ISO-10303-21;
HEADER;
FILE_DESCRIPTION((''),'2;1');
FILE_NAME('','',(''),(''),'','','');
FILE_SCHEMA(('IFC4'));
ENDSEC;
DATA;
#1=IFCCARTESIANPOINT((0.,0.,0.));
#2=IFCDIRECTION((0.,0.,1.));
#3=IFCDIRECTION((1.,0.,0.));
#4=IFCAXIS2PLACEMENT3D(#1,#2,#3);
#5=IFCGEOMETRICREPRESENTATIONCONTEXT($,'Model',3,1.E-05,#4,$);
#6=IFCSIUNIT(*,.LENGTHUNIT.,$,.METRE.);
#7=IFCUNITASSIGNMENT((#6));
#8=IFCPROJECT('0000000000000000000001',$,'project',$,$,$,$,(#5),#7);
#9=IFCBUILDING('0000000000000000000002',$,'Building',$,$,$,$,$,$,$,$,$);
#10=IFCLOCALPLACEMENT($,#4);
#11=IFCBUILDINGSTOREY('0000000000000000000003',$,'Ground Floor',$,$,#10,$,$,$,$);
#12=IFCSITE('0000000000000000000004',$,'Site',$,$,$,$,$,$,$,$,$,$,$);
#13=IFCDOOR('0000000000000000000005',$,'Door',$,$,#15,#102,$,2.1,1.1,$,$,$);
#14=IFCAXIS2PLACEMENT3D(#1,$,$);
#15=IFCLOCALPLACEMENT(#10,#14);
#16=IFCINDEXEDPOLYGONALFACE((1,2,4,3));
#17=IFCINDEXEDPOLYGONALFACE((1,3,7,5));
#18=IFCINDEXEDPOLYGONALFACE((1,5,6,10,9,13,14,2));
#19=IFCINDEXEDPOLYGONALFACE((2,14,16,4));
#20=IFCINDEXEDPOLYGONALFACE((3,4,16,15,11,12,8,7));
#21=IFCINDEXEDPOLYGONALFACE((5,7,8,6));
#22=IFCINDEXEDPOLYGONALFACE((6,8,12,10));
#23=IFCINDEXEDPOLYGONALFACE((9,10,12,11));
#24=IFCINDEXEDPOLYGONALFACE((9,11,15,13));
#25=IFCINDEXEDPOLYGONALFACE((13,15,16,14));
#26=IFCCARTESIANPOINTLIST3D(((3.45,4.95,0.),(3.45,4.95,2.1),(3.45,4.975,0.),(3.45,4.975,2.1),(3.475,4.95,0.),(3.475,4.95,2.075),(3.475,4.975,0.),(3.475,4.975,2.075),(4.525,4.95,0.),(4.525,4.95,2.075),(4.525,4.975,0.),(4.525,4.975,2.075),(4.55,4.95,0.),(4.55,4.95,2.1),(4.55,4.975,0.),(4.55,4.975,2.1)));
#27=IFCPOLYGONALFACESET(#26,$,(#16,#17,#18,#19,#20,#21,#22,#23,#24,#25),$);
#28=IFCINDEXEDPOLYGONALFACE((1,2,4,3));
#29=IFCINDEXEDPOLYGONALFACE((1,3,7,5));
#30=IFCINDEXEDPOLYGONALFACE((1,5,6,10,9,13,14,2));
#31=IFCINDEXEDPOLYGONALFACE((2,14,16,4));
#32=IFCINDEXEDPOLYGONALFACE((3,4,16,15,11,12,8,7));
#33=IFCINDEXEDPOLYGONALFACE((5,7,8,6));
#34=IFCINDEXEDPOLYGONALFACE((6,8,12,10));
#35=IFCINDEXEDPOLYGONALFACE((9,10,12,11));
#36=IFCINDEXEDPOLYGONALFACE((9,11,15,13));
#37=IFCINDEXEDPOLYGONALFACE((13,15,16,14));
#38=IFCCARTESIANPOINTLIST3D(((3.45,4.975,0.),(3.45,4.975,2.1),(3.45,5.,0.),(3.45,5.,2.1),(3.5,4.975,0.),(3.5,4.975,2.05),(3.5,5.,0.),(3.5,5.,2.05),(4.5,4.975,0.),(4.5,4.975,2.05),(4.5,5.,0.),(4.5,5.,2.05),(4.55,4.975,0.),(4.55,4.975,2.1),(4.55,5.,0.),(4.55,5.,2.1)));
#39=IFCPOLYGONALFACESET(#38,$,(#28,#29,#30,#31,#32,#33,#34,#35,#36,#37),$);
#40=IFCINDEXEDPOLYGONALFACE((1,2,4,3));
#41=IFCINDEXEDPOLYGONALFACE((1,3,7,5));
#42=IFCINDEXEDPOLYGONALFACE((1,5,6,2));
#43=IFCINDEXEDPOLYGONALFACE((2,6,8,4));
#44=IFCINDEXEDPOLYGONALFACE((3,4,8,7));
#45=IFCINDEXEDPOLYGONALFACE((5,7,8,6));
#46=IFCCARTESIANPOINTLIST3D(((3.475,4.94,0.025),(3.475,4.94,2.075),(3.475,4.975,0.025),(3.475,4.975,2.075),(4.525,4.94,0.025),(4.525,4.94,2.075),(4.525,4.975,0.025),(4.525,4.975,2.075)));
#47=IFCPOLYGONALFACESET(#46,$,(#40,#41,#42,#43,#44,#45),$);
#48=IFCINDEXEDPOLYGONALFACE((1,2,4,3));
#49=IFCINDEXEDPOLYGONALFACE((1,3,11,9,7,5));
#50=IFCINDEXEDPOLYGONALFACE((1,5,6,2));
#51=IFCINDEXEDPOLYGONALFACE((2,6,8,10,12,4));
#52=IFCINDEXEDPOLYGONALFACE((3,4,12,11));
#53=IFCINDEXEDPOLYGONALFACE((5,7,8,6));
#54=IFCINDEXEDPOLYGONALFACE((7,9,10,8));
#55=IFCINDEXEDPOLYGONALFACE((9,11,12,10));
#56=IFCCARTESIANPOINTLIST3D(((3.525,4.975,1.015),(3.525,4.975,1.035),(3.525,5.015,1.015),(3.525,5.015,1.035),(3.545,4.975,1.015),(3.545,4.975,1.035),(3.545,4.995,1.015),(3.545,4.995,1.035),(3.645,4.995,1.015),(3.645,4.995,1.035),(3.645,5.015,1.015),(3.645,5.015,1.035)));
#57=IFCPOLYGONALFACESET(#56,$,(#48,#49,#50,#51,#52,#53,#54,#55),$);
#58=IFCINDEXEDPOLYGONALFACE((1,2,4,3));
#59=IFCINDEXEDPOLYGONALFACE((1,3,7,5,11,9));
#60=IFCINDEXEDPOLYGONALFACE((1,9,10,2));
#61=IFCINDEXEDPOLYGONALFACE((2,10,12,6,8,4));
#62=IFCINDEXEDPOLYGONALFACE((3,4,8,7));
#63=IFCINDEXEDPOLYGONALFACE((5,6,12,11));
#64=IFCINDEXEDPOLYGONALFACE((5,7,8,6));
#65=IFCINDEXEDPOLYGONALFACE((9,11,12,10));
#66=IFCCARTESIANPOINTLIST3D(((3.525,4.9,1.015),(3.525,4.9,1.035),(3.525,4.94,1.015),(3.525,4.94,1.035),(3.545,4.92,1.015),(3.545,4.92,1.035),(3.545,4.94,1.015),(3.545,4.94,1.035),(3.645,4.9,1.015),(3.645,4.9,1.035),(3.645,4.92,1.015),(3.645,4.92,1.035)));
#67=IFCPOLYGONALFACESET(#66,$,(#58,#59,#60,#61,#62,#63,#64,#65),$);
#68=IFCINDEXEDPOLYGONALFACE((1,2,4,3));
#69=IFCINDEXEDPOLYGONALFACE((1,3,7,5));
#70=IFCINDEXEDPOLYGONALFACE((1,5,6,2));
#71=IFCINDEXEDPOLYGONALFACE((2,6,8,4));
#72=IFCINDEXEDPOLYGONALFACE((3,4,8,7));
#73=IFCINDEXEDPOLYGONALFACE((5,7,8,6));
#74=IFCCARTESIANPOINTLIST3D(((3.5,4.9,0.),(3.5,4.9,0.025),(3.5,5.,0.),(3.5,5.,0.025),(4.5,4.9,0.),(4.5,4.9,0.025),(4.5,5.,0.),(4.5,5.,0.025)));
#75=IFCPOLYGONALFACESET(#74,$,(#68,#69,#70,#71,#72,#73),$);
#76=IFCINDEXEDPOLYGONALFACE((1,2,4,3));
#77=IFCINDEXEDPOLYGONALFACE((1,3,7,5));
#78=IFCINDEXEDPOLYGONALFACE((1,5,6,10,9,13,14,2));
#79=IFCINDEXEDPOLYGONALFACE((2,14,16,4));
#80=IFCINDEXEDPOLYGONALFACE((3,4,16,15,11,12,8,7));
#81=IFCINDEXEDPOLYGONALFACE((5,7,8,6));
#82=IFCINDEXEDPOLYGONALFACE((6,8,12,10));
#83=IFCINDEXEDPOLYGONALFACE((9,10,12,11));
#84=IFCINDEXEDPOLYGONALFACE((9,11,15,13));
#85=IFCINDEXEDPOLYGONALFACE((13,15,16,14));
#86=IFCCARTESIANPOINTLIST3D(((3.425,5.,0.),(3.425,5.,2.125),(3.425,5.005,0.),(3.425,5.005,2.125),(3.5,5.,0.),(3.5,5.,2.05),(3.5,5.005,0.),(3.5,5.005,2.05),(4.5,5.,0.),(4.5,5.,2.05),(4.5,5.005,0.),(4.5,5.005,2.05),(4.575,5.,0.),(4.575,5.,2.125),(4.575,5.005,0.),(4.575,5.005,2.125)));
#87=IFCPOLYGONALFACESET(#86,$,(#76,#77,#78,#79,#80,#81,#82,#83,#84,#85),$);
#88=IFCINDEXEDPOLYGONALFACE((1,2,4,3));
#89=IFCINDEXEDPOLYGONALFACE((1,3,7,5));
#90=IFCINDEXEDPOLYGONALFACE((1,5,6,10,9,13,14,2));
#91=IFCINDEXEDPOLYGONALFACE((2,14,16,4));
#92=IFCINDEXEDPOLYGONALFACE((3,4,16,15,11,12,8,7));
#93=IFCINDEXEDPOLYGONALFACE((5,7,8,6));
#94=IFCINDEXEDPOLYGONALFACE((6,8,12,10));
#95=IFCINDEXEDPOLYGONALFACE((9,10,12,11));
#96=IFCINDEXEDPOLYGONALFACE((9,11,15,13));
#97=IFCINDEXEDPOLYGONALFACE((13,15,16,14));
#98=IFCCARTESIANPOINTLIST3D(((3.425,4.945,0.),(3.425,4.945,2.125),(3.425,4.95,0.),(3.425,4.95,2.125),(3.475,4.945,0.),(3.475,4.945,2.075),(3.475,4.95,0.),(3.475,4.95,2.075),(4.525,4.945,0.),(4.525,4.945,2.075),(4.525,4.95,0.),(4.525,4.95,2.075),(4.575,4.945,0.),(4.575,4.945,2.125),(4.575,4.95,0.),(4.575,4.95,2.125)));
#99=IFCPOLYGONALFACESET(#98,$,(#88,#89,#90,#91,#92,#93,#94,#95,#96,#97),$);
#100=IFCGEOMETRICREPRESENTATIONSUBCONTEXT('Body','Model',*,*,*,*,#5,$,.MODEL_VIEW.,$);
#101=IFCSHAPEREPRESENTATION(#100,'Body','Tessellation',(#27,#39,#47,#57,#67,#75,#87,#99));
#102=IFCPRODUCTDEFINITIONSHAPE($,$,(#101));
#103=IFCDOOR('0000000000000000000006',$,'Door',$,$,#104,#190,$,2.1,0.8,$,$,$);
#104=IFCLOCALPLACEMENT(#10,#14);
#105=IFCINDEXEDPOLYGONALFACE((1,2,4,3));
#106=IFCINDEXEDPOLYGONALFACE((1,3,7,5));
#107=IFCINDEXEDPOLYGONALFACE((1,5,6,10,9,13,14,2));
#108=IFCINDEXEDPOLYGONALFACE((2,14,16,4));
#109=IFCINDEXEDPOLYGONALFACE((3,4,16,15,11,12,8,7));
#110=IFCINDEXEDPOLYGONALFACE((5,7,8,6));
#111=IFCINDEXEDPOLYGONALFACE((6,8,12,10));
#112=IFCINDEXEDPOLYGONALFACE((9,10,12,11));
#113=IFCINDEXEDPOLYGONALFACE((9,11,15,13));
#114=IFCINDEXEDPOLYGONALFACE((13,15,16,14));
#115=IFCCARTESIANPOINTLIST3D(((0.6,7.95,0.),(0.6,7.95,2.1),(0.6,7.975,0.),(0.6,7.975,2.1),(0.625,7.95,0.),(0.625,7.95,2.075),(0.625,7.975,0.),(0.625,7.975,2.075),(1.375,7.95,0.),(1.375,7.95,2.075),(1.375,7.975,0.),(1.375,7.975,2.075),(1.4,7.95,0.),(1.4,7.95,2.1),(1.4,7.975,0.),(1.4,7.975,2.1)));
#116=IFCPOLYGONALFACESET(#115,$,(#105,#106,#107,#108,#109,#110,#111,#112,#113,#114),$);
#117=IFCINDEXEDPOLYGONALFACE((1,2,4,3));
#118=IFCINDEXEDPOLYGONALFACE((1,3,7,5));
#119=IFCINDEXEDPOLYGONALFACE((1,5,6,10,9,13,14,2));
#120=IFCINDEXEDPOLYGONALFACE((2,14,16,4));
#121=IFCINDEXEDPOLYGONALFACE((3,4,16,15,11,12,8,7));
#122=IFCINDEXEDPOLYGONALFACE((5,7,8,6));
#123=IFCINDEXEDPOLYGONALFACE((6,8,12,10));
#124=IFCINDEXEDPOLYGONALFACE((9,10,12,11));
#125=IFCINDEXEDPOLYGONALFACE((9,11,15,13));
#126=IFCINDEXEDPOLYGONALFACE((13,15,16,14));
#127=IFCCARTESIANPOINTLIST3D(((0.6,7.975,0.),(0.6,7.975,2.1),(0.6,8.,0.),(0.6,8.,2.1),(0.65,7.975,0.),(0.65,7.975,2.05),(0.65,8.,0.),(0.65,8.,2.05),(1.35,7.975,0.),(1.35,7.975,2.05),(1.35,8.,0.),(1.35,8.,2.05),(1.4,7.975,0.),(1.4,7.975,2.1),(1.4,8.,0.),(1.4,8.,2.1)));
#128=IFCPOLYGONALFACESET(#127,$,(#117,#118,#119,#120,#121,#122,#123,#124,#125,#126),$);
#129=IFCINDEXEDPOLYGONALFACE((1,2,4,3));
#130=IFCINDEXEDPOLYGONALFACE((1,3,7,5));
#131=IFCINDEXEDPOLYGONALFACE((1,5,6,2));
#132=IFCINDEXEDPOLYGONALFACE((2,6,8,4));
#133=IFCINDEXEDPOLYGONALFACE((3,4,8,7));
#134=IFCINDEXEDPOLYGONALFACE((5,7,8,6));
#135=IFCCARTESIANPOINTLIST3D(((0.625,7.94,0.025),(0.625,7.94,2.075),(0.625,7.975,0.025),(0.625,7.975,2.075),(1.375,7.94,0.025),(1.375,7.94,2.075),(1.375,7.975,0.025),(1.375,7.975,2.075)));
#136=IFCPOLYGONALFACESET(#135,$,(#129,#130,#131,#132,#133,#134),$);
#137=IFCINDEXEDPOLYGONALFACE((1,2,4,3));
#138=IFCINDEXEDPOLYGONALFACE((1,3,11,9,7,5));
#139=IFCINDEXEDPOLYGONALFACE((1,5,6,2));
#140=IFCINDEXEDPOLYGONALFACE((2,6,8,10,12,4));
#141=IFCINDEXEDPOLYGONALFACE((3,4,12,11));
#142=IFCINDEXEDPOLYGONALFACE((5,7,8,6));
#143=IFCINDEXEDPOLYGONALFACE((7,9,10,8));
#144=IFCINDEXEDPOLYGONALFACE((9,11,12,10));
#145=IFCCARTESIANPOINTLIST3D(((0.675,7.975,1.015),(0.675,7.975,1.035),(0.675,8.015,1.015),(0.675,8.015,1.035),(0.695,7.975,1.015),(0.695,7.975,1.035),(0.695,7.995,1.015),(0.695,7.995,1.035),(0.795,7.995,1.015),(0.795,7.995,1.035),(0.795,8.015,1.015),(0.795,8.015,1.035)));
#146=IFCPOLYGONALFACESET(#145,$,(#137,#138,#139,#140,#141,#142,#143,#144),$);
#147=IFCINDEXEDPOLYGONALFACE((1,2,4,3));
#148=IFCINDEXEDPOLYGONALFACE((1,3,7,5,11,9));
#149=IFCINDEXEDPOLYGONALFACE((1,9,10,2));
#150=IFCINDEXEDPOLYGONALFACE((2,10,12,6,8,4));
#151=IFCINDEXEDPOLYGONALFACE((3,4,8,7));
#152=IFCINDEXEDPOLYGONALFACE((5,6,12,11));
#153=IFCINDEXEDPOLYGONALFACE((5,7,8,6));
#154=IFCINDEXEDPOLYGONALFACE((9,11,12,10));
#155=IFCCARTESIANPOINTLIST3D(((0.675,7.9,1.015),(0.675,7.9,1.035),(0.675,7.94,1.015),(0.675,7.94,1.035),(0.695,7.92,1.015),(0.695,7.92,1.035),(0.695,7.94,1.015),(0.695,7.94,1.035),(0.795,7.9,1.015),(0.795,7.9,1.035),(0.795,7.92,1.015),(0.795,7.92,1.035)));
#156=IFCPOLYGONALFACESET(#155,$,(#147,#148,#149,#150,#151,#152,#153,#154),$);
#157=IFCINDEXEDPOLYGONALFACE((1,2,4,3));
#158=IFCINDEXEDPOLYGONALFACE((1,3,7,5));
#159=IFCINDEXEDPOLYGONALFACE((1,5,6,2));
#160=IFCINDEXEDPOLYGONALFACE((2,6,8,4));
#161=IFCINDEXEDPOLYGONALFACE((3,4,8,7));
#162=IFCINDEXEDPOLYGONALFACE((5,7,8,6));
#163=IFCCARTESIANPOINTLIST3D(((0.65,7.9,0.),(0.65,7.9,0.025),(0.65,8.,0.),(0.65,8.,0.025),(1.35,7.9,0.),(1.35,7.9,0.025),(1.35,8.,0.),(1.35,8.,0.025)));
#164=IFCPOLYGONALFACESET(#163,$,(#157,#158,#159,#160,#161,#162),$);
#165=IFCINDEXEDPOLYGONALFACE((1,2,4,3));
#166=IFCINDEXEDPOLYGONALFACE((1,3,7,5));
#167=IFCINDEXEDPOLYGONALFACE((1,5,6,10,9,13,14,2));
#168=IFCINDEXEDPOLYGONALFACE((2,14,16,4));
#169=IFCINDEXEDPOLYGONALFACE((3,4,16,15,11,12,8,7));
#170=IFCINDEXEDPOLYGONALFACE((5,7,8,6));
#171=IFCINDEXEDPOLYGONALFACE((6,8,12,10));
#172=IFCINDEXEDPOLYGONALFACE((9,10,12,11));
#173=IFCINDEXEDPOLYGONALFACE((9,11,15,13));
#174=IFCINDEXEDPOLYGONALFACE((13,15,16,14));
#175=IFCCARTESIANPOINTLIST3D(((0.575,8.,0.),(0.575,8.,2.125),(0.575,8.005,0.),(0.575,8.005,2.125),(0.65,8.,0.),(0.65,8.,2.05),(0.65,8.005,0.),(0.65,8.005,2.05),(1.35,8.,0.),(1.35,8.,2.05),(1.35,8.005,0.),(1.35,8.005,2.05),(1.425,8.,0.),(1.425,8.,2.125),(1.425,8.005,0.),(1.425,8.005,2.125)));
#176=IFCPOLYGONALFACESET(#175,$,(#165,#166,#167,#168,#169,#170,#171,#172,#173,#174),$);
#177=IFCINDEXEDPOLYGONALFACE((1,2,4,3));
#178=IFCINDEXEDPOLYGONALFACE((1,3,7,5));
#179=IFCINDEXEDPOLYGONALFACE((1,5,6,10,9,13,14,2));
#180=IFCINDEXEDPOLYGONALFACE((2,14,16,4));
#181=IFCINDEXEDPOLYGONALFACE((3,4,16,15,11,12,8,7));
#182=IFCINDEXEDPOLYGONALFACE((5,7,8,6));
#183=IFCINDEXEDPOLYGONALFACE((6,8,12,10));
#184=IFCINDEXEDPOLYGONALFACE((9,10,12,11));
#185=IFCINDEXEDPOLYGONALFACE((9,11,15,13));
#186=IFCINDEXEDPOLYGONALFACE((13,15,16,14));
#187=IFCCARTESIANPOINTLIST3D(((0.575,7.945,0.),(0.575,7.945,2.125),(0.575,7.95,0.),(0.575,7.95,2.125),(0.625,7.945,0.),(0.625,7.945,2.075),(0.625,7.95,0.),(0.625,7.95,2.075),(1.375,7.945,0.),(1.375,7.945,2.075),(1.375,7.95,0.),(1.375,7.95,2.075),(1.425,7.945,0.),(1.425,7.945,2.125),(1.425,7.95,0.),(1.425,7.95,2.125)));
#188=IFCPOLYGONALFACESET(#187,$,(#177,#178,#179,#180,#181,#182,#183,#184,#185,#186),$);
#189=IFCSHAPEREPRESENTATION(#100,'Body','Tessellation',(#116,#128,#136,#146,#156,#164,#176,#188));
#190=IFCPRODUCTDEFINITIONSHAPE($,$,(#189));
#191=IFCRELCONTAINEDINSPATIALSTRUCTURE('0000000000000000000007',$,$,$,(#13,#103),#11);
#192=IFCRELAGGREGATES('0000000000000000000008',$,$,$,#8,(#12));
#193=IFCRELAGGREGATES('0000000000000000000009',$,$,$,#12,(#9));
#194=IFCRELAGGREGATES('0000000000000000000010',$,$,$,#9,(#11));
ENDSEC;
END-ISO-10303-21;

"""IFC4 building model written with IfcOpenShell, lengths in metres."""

from ifc_helpers import new_model, si_unit, frame, origin_with_axes, place, context, subcontext, project, spatial, line, indexed_curve, outline, extrude, element, save


model = new_model("IFC4")

# Units and contexts
model_context = context("Model", 3, precision=1e-05, world=origin_with_axes())
body_context = subcontext(model_context, "Body", "Model", "MODEL_VIEW")
ifc_project = project(units=[si_unit("LENGTHUNIT", "METRE")], contexts=[model_context])

# Site, building, storey
site = spatial("IfcSite", under=ifc_project, Name="Site")
building = spatial("IfcBuilding", under=site, Name="Building")
storey_placement = place(None, origin_with_axes())
storey = spatial("IfcBuildingStorey", under=building, at=storey_placement, Name="Ground Floor")

# Doors
door_1_placement = place(storey_placement, frame((4.55, 5.0, 0.0), z_axis=(0.0, 0.0, 1.0), x_axis=(-1.0, 0.0, 0.0)))
element("IfcDoor", 1, at=door_1_placement, inside=storey, Name="Door", OverallHeight=2.1, OverallWidth=1.1, context=body_context, shape_type="SweptSolid", body=[
    extrude(outline(indexed_curve([(0.0, 0.0), (0.0, 2.1), (1.1, 2.1), (1.1, 0.0), (1.075, 0.0), (1.075, 2.075), (0.025, 2.075), (0.025, 0.0)], segments=[line(1, 2, 3, 4, 5, 6, 7, 8, 1)])), frame((0.0, 0.025, 0.0), z_axis=(0.0, -1.0, 0.0), x_axis=(1.0, 0.0, 0.0)), (0.0, 0.0, -1.0), 0.025),
    extrude(outline(indexed_curve([(0.0, 0.0), (0.0, 2.1), (1.1, 2.1), (1.1, 0.0), (1.05, 0.0), (1.05, 2.05), (0.05, 2.05), (0.05, 0.0)], segments=[line(1, 2, 3, 4, 5, 6, 7, 8, 1)])), frame((0.0, 0.0, 0.0), z_axis=(0.0, -1.0, 0.0), x_axis=(1.0, 0.0, 0.0)), (0.0, 0.0, -1.0), 0.025),
    extrude(outline(indexed_curve([(0.0, 0.0), (1.05, 0.0), (1.05, 0.035), (0.0, 0.035)], segments=[line(1, 2, 3, 4, 1)])), frame((0.025, 0.025, 0.025), z_axis=(0.0, 0.0, 1.0), x_axis=(1.0, 0.0, 0.0)), (0.0, 0.0, 1.0), 2.05),
    extrude(outline(indexed_curve([(0.0, 0.0), (0.0, -0.04), (-0.12, -0.04), (-0.12, -0.02), (-0.02, -0.02), (-0.02, 0.0)], segments=[line(1, 2, 3, 4, 5, 6, 1)])), frame((1.025, 0.025, 1.015), z_axis=(0.0, 0.0, 1.0), x_axis=(1.0, 0.0, 0.0)), (0.0, 0.0, 1.0), 0.02),
    extrude(outline(indexed_curve([(0.0, 0.0), (0.0, 0.04), (-0.12, 0.04), (-0.12, 0.02), (-0.02, 0.02), (-0.02, 0.0)], segments=[line(1, 2, 3, 4, 5, 6, 1)])), frame((1.025, 0.06, 1.015), z_axis=(0.0, 0.0, 1.0), x_axis=(1.0, 0.0, 0.0)), (0.0, 0.0, 1.0), 0.02),
    extrude(outline(indexed_curve([(0.0, 0.0), (1.0, 0.0), (1.0, 0.1), (0.0, 0.1)], segments=[line(1, 2, 3, 4, 1)])), frame((0.05, 0.0, 0.0), z_axis=(0.0, 0.0, 1.0), x_axis=(1.0, 0.0, 0.0)), (0.0, 0.0, 1.0), 0.025),
    extrude(outline(indexed_curve([(0.0, 0.0), (0.0, 2.125), (1.15, 2.125), (1.15, 0.0), (1.075, 0.0), (1.075, 2.05), (0.075, 2.05), (0.075, 0.0)], segments=[line(1, 2, 3, 4, 5, 6, 7, 8, 1)])), frame((-0.025, -0.005, 0.0), z_axis=(0.0, -1.0, 0.0), x_axis=(1.0, 0.0, 0.0)), (0.0, 0.0, -1.0), 0.005),
    extrude(outline(indexed_curve([(0.0, 0.0), (0.0, 2.125), (1.15, 2.125), (1.15, 0.0), (1.1, 0.0), (1.1, 2.075), (0.05, 2.075), (0.05, 0.0)], segments=[line(1, 2, 3, 4, 5, 6, 7, 8, 1)])), frame((-0.025, 0.05, 0.0), z_axis=(0.0, -1.0, 0.0), x_axis=(1.0, 0.0, 0.0)), (0.0, 0.0, -1.0), 0.005),
])
door_2_placement = place(storey_placement, frame((1.4, 8.0, 0.0), z_axis=(0.0, 0.0, 1.0), x_axis=(-1.0, 0.0, 0.0)))
element("IfcDoor", 2, at=door_2_placement, inside=storey, Name="Door", OverallHeight=2.1, OverallWidth=0.8, context=body_context, shape_type="SweptSolid", body=[
    extrude(outline(indexed_curve([(0.0, 0.0), (0.0, 2.1), (0.8, 2.1), (0.8, 0.0), (0.775, 0.0), (0.775, 2.075), (0.025, 2.075), (0.025, 0.0)], segments=[line(1, 2, 3, 4, 5, 6, 7, 8, 1)])), frame((0.0, 0.025, 0.0), z_axis=(0.0, -1.0, 0.0), x_axis=(1.0, 0.0, 0.0)), (0.0, 0.0, -1.0), 0.025),
    extrude(outline(indexed_curve([(0.0, 0.0), (0.0, 2.1), (0.8, 2.1), (0.8, 0.0), (0.75, 0.0), (0.75, 2.05), (0.05, 2.05), (0.05, 0.0)], segments=[line(1, 2, 3, 4, 5, 6, 7, 8, 1)])), frame((0.0, 0.0, 0.0), z_axis=(0.0, -1.0, 0.0), x_axis=(1.0, 0.0, 0.0)), (0.0, 0.0, -1.0), 0.025),
    extrude(outline(indexed_curve([(0.0, 0.0), (0.75, 0.0), (0.75, 0.035), (0.0, 0.035)], segments=[line(1, 2, 3, 4, 1)])), frame((0.025, 0.025, 0.025), z_axis=(0.0, 0.0, 1.0), x_axis=(1.0, 0.0, 0.0)), (0.0, 0.0, 1.0), 2.05),
    extrude(outline(indexed_curve([(0.0, 0.0), (0.0, -0.04), (-0.12, -0.04), (-0.12, -0.02), (-0.02, -0.02), (-0.02, 0.0)], segments=[line(1, 2, 3, 4, 5, 6, 1)])), frame((0.725, 0.025, 1.015), z_axis=(0.0, 0.0, 1.0), x_axis=(1.0, 0.0, 0.0)), (0.0, 0.0, 1.0), 0.02),
    extrude(outline(indexed_curve([(0.0, 0.0), (0.0, 0.04), (-0.12, 0.04), (-0.12, 0.02), (-0.02, 0.02), (-0.02, 0.0)], segments=[line(1, 2, 3, 4, 5, 6, 1)])), frame((0.725, 0.06, 1.015), z_axis=(0.0, 0.0, 1.0), x_axis=(1.0, 0.0, 0.0)), (0.0, 0.0, 1.0), 0.02),
    extrude(outline(indexed_curve([(0.0, 0.0), (0.7, 0.0), (0.7, 0.1), (0.0, 0.1)], segments=[line(1, 2, 3, 4, 1)])), frame((0.05, 0.0, 0.0), z_axis=(0.0, 0.0, 1.0), x_axis=(1.0, 0.0, 0.0)), (0.0, 0.0, 1.0), 0.025),
    extrude(outline(indexed_curve([(0.0, 0.0), (0.0, 2.125), (0.85, 2.125), (0.85, 0.0), (0.775, 0.0), (0.775, 2.05), (0.075, 2.05), (0.075, 0.0)], segments=[line(1, 2, 3, 4, 5, 6, 7, 8, 1)])), frame((-0.025, -0.005, 0.0), z_axis=(0.0, -1.0, 0.0), x_axis=(1.0, 0.0, 0.0)), (0.0, 0.0, -1.0), 0.005),
    extrude(outline(indexed_curve([(0.0, 0.0), (0.0, 2.125), (0.85, 2.125), (0.85, 0.0), (0.8, 0.0), (0.8, 2.075), (0.05, 2.075), (0.05, 0.0)], segments=[line(1, 2, 3, 4, 5, 6, 7, 8, 1)])), frame((-0.025, 0.05, 0.0), z_axis=(0.0, -1.0, 0.0), x_axis=(1.0, 0.0, 0.0)), (0.0, 0.0, -1.0), 0.005),
])

save(model, "model.ifc")
